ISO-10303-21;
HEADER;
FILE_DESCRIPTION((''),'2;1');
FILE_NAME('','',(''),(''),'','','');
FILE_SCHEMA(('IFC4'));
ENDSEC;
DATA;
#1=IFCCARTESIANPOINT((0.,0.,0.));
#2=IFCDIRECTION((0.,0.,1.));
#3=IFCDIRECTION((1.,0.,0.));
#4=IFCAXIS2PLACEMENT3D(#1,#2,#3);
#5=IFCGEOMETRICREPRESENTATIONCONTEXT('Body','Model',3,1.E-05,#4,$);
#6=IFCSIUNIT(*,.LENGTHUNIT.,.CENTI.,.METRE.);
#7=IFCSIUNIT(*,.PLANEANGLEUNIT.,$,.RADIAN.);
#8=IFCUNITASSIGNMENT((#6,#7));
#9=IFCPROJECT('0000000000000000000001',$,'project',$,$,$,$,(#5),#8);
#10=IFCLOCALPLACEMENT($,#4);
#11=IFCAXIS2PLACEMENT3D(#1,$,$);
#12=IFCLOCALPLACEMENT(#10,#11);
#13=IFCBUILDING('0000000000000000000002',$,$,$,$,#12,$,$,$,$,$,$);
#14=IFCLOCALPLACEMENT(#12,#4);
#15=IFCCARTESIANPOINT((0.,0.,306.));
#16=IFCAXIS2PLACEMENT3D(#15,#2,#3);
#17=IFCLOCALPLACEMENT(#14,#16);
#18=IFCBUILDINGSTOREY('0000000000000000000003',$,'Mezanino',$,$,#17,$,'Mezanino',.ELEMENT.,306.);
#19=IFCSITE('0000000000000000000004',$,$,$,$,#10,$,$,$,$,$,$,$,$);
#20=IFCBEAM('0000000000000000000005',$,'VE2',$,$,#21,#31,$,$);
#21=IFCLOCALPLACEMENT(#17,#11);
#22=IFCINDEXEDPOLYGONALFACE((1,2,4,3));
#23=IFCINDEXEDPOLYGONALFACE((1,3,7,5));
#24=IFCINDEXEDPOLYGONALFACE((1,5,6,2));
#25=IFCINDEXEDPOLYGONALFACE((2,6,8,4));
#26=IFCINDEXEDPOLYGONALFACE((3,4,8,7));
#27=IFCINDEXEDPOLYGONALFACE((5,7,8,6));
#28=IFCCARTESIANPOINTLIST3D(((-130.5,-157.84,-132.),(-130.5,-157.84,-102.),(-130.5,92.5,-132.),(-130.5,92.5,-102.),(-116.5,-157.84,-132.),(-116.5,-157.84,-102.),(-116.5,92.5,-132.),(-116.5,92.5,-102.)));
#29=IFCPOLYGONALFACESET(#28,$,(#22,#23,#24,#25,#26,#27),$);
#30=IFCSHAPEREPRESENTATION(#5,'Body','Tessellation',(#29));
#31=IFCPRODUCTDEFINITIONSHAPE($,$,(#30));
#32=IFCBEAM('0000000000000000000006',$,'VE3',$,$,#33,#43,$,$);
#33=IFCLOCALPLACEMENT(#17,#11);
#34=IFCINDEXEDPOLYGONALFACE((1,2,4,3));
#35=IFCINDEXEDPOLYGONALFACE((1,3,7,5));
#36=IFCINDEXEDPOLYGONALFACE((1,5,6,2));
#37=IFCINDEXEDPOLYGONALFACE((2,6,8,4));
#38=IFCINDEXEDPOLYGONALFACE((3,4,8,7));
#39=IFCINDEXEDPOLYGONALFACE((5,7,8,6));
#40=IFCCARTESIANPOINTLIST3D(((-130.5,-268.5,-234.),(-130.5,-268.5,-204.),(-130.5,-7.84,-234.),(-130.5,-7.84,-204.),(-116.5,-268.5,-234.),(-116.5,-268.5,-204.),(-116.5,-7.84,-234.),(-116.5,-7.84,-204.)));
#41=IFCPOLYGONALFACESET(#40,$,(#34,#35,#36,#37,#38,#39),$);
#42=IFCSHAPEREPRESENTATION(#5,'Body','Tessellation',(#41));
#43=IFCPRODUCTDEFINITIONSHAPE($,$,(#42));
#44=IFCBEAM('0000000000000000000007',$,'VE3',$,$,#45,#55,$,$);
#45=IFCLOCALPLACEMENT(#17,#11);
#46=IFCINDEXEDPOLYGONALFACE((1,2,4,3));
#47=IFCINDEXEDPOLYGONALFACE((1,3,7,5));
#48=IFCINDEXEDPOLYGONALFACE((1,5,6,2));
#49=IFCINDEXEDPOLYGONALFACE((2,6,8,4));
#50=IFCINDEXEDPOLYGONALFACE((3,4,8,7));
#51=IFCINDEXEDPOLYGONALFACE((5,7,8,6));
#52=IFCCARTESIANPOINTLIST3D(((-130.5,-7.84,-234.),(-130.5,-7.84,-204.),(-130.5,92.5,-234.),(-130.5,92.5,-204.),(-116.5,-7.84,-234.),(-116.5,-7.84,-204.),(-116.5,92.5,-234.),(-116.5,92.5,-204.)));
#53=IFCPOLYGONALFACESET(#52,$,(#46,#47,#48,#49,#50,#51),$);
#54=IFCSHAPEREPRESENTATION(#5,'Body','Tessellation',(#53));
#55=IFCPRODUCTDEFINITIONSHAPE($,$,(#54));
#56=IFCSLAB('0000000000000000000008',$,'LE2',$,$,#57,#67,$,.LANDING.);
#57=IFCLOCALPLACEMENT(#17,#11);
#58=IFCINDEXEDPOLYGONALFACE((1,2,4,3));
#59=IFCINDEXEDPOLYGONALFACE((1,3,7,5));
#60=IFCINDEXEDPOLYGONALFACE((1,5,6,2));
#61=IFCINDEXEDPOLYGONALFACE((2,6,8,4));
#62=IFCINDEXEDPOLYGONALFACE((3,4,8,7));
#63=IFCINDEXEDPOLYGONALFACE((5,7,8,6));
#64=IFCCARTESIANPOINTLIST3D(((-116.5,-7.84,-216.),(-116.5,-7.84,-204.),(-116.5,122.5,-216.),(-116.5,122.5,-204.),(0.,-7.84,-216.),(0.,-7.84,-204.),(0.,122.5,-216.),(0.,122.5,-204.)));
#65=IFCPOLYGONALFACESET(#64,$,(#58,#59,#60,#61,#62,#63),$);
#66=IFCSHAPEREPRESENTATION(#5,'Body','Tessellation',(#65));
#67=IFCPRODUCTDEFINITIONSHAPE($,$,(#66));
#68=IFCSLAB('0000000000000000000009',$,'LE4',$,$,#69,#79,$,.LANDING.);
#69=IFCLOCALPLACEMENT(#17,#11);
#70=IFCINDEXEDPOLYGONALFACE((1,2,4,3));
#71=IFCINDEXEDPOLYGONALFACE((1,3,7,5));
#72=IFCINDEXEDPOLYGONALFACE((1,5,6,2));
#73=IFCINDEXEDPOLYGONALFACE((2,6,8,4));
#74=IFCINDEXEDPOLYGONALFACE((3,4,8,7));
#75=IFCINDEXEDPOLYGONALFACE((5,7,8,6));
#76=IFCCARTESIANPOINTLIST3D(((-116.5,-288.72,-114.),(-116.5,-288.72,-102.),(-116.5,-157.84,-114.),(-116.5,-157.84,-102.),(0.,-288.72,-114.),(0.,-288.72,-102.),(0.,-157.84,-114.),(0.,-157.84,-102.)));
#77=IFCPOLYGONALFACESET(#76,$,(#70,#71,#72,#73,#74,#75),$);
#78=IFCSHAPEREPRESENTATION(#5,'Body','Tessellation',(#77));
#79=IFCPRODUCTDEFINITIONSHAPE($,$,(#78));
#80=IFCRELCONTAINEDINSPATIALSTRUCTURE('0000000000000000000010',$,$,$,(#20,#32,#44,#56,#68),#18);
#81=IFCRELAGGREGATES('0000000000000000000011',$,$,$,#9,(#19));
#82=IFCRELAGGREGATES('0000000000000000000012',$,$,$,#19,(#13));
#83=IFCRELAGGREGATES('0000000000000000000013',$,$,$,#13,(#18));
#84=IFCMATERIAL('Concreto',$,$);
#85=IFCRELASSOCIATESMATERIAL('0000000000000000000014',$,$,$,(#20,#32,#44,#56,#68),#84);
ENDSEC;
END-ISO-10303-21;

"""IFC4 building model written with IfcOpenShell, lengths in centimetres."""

from ifc_helpers import new_model, si_unit, frame, origin, origin_with_axes, origin_2d_with_axis, place, context, project, spatial, polyline, rectangle, outline, extrude, material, element, save


model = new_model("IFC4")

# Units and contexts
model_context = context("Model", 3, precision=1e-05, world=origin_with_axes(), identifier="Body")
ifc_project = project(units=[si_unit("LENGTHUNIT", "METRE", prefix="CENTI"), si_unit("PLANEANGLEUNIT", "RADIAN")], contexts=[model_context])

# Site, building, storey
site_placement = place(None, origin_with_axes())
site = spatial("IfcSite", under=ifc_project, at=site_placement)
building_placement = place(site_placement, origin())
building = spatial("IfcBuilding", under=site, at=building_placement)
placement = place(building_placement, origin_with_axes())
storey_placement = place(placement, frame((0.0, 0.0, 306.0), z_axis=(0.0, 0.0, 1.0), x_axis=(1.0, 0.0, 0.0)))
storey = spatial("IfcBuildingStorey", under=building, at=storey_placement, Name="Mezanino", LongName="Mezanino", CompositionType="ELEMENT", Elevation=306.0)

# Shared definitions
ifc_material_1 = material(Name="Concreto")

# Beams
beam_1_placement = place(storey_placement, frame((-123.5, -32.67, -102.0), z_axis=(0.0, 0.0, 1.0), x_axis=(1.0, 0.0, 0.0)))
element("IfcBeam", 1, at=beam_1_placement, inside=storey, material=ifc_material_1, Name="VE2", context=model_context, shape_type="SolidModel", body=[
    extrude(rectangle(XDim=14.0, YDim=30.0, at=origin_2d_with_axis()), frame((0.0, -125.17, -15.0), z_axis=(0.0, 1.0, 0.0), x_axis=(-1.0, 0.0, 0.0)), (0.0, 0.0, 1.0), 250.34),
])
beam_2_placement = place(storey_placement, frame((-123.5, -138.17, -204.0), z_axis=(0.0, 0.0, 1.0), x_axis=(1.0, 0.0, 0.0)))
element("IfcBeam", 2, at=beam_2_placement, inside=storey, material=ifc_material_1, Name="VE3", context=model_context, shape_type="SolidModel", body=[
    extrude(rectangle(XDim=14.0, YDim=30.0, at=origin_2d_with_axis()), frame((0.0, -130.33, -15.0), z_axis=(0.0, 1.0, 0.0), x_axis=(1.0, 0.0, 0.0)), (0.0, 0.0, 1.0), 260.66),
])
beam_3_placement = place(storey_placement, frame((-123.5, 42.33, -204.0), z_axis=(0.0, 0.0, 1.0), x_axis=(1.0, 0.0, 0.0)))
element("IfcBeam", 3, at=beam_3_placement, inside=storey, material=ifc_material_1, Name="VE3", context=model_context, shape_type="SolidModel", body=[
    extrude(rectangle(XDim=14.0, YDim=30.0, at=origin_2d_with_axis()), frame((0.0, -50.17, -15.0), z_axis=(0.0, 1.0, 0.0), x_axis=(-1.0, 0.0, 0.0)), (0.0, 0.0, 1.0), 100.34),
])

# Slabs
slab_1_placement = place(storey_placement, frame((-58.25, 57.33, -204.0), z_axis=(0.0, 0.0, 1.0), x_axis=(1.0, 0.0, 0.0)))
element("IfcSlab", 4, at=slab_1_placement, inside=storey, material=ifc_material_1, Name="LE2", PredefinedType="LANDING", context=model_context, shape_type="SolidModel", body=[
    extrude(outline(polyline([(58.25, 65.17), (-58.25, 65.17), (-58.25, -65.17), (58.25, -65.17), (58.25, 65.17), (58.25, 65.17)])), frame((0.0, 0.0, -12.0), z_axis=(0.0, 0.0, 1.0), x_axis=(1.0, 0.0, 0.0)), (0.0, 0.0, 1.0), 12.0),
])
slab_2_placement = place(storey_placement, frame((-58.25, -223.28, -102.0), z_axis=(0.0, 0.0, 1.0), x_axis=(1.0, 0.0, 0.0)))
element("IfcSlab", 5, at=slab_2_placement, inside=storey, material=ifc_material_1, Name="LE4", PredefinedType="LANDING", context=model_context, shape_type="SolidModel", body=[
    extrude(outline(polyline([(58.25, 65.44), (-58.25, 65.44), (-58.25, -65.44), (58.25, -65.44), (58.25, 65.44), (58.25, 65.44)])), frame((0.0, 0.0, -12.0), z_axis=(0.0, 0.0, 1.0), x_axis=(1.0, 0.0, 0.0)), (0.0, 0.0, 1.0), 12.0),
])

save(model, "model.ifc")
